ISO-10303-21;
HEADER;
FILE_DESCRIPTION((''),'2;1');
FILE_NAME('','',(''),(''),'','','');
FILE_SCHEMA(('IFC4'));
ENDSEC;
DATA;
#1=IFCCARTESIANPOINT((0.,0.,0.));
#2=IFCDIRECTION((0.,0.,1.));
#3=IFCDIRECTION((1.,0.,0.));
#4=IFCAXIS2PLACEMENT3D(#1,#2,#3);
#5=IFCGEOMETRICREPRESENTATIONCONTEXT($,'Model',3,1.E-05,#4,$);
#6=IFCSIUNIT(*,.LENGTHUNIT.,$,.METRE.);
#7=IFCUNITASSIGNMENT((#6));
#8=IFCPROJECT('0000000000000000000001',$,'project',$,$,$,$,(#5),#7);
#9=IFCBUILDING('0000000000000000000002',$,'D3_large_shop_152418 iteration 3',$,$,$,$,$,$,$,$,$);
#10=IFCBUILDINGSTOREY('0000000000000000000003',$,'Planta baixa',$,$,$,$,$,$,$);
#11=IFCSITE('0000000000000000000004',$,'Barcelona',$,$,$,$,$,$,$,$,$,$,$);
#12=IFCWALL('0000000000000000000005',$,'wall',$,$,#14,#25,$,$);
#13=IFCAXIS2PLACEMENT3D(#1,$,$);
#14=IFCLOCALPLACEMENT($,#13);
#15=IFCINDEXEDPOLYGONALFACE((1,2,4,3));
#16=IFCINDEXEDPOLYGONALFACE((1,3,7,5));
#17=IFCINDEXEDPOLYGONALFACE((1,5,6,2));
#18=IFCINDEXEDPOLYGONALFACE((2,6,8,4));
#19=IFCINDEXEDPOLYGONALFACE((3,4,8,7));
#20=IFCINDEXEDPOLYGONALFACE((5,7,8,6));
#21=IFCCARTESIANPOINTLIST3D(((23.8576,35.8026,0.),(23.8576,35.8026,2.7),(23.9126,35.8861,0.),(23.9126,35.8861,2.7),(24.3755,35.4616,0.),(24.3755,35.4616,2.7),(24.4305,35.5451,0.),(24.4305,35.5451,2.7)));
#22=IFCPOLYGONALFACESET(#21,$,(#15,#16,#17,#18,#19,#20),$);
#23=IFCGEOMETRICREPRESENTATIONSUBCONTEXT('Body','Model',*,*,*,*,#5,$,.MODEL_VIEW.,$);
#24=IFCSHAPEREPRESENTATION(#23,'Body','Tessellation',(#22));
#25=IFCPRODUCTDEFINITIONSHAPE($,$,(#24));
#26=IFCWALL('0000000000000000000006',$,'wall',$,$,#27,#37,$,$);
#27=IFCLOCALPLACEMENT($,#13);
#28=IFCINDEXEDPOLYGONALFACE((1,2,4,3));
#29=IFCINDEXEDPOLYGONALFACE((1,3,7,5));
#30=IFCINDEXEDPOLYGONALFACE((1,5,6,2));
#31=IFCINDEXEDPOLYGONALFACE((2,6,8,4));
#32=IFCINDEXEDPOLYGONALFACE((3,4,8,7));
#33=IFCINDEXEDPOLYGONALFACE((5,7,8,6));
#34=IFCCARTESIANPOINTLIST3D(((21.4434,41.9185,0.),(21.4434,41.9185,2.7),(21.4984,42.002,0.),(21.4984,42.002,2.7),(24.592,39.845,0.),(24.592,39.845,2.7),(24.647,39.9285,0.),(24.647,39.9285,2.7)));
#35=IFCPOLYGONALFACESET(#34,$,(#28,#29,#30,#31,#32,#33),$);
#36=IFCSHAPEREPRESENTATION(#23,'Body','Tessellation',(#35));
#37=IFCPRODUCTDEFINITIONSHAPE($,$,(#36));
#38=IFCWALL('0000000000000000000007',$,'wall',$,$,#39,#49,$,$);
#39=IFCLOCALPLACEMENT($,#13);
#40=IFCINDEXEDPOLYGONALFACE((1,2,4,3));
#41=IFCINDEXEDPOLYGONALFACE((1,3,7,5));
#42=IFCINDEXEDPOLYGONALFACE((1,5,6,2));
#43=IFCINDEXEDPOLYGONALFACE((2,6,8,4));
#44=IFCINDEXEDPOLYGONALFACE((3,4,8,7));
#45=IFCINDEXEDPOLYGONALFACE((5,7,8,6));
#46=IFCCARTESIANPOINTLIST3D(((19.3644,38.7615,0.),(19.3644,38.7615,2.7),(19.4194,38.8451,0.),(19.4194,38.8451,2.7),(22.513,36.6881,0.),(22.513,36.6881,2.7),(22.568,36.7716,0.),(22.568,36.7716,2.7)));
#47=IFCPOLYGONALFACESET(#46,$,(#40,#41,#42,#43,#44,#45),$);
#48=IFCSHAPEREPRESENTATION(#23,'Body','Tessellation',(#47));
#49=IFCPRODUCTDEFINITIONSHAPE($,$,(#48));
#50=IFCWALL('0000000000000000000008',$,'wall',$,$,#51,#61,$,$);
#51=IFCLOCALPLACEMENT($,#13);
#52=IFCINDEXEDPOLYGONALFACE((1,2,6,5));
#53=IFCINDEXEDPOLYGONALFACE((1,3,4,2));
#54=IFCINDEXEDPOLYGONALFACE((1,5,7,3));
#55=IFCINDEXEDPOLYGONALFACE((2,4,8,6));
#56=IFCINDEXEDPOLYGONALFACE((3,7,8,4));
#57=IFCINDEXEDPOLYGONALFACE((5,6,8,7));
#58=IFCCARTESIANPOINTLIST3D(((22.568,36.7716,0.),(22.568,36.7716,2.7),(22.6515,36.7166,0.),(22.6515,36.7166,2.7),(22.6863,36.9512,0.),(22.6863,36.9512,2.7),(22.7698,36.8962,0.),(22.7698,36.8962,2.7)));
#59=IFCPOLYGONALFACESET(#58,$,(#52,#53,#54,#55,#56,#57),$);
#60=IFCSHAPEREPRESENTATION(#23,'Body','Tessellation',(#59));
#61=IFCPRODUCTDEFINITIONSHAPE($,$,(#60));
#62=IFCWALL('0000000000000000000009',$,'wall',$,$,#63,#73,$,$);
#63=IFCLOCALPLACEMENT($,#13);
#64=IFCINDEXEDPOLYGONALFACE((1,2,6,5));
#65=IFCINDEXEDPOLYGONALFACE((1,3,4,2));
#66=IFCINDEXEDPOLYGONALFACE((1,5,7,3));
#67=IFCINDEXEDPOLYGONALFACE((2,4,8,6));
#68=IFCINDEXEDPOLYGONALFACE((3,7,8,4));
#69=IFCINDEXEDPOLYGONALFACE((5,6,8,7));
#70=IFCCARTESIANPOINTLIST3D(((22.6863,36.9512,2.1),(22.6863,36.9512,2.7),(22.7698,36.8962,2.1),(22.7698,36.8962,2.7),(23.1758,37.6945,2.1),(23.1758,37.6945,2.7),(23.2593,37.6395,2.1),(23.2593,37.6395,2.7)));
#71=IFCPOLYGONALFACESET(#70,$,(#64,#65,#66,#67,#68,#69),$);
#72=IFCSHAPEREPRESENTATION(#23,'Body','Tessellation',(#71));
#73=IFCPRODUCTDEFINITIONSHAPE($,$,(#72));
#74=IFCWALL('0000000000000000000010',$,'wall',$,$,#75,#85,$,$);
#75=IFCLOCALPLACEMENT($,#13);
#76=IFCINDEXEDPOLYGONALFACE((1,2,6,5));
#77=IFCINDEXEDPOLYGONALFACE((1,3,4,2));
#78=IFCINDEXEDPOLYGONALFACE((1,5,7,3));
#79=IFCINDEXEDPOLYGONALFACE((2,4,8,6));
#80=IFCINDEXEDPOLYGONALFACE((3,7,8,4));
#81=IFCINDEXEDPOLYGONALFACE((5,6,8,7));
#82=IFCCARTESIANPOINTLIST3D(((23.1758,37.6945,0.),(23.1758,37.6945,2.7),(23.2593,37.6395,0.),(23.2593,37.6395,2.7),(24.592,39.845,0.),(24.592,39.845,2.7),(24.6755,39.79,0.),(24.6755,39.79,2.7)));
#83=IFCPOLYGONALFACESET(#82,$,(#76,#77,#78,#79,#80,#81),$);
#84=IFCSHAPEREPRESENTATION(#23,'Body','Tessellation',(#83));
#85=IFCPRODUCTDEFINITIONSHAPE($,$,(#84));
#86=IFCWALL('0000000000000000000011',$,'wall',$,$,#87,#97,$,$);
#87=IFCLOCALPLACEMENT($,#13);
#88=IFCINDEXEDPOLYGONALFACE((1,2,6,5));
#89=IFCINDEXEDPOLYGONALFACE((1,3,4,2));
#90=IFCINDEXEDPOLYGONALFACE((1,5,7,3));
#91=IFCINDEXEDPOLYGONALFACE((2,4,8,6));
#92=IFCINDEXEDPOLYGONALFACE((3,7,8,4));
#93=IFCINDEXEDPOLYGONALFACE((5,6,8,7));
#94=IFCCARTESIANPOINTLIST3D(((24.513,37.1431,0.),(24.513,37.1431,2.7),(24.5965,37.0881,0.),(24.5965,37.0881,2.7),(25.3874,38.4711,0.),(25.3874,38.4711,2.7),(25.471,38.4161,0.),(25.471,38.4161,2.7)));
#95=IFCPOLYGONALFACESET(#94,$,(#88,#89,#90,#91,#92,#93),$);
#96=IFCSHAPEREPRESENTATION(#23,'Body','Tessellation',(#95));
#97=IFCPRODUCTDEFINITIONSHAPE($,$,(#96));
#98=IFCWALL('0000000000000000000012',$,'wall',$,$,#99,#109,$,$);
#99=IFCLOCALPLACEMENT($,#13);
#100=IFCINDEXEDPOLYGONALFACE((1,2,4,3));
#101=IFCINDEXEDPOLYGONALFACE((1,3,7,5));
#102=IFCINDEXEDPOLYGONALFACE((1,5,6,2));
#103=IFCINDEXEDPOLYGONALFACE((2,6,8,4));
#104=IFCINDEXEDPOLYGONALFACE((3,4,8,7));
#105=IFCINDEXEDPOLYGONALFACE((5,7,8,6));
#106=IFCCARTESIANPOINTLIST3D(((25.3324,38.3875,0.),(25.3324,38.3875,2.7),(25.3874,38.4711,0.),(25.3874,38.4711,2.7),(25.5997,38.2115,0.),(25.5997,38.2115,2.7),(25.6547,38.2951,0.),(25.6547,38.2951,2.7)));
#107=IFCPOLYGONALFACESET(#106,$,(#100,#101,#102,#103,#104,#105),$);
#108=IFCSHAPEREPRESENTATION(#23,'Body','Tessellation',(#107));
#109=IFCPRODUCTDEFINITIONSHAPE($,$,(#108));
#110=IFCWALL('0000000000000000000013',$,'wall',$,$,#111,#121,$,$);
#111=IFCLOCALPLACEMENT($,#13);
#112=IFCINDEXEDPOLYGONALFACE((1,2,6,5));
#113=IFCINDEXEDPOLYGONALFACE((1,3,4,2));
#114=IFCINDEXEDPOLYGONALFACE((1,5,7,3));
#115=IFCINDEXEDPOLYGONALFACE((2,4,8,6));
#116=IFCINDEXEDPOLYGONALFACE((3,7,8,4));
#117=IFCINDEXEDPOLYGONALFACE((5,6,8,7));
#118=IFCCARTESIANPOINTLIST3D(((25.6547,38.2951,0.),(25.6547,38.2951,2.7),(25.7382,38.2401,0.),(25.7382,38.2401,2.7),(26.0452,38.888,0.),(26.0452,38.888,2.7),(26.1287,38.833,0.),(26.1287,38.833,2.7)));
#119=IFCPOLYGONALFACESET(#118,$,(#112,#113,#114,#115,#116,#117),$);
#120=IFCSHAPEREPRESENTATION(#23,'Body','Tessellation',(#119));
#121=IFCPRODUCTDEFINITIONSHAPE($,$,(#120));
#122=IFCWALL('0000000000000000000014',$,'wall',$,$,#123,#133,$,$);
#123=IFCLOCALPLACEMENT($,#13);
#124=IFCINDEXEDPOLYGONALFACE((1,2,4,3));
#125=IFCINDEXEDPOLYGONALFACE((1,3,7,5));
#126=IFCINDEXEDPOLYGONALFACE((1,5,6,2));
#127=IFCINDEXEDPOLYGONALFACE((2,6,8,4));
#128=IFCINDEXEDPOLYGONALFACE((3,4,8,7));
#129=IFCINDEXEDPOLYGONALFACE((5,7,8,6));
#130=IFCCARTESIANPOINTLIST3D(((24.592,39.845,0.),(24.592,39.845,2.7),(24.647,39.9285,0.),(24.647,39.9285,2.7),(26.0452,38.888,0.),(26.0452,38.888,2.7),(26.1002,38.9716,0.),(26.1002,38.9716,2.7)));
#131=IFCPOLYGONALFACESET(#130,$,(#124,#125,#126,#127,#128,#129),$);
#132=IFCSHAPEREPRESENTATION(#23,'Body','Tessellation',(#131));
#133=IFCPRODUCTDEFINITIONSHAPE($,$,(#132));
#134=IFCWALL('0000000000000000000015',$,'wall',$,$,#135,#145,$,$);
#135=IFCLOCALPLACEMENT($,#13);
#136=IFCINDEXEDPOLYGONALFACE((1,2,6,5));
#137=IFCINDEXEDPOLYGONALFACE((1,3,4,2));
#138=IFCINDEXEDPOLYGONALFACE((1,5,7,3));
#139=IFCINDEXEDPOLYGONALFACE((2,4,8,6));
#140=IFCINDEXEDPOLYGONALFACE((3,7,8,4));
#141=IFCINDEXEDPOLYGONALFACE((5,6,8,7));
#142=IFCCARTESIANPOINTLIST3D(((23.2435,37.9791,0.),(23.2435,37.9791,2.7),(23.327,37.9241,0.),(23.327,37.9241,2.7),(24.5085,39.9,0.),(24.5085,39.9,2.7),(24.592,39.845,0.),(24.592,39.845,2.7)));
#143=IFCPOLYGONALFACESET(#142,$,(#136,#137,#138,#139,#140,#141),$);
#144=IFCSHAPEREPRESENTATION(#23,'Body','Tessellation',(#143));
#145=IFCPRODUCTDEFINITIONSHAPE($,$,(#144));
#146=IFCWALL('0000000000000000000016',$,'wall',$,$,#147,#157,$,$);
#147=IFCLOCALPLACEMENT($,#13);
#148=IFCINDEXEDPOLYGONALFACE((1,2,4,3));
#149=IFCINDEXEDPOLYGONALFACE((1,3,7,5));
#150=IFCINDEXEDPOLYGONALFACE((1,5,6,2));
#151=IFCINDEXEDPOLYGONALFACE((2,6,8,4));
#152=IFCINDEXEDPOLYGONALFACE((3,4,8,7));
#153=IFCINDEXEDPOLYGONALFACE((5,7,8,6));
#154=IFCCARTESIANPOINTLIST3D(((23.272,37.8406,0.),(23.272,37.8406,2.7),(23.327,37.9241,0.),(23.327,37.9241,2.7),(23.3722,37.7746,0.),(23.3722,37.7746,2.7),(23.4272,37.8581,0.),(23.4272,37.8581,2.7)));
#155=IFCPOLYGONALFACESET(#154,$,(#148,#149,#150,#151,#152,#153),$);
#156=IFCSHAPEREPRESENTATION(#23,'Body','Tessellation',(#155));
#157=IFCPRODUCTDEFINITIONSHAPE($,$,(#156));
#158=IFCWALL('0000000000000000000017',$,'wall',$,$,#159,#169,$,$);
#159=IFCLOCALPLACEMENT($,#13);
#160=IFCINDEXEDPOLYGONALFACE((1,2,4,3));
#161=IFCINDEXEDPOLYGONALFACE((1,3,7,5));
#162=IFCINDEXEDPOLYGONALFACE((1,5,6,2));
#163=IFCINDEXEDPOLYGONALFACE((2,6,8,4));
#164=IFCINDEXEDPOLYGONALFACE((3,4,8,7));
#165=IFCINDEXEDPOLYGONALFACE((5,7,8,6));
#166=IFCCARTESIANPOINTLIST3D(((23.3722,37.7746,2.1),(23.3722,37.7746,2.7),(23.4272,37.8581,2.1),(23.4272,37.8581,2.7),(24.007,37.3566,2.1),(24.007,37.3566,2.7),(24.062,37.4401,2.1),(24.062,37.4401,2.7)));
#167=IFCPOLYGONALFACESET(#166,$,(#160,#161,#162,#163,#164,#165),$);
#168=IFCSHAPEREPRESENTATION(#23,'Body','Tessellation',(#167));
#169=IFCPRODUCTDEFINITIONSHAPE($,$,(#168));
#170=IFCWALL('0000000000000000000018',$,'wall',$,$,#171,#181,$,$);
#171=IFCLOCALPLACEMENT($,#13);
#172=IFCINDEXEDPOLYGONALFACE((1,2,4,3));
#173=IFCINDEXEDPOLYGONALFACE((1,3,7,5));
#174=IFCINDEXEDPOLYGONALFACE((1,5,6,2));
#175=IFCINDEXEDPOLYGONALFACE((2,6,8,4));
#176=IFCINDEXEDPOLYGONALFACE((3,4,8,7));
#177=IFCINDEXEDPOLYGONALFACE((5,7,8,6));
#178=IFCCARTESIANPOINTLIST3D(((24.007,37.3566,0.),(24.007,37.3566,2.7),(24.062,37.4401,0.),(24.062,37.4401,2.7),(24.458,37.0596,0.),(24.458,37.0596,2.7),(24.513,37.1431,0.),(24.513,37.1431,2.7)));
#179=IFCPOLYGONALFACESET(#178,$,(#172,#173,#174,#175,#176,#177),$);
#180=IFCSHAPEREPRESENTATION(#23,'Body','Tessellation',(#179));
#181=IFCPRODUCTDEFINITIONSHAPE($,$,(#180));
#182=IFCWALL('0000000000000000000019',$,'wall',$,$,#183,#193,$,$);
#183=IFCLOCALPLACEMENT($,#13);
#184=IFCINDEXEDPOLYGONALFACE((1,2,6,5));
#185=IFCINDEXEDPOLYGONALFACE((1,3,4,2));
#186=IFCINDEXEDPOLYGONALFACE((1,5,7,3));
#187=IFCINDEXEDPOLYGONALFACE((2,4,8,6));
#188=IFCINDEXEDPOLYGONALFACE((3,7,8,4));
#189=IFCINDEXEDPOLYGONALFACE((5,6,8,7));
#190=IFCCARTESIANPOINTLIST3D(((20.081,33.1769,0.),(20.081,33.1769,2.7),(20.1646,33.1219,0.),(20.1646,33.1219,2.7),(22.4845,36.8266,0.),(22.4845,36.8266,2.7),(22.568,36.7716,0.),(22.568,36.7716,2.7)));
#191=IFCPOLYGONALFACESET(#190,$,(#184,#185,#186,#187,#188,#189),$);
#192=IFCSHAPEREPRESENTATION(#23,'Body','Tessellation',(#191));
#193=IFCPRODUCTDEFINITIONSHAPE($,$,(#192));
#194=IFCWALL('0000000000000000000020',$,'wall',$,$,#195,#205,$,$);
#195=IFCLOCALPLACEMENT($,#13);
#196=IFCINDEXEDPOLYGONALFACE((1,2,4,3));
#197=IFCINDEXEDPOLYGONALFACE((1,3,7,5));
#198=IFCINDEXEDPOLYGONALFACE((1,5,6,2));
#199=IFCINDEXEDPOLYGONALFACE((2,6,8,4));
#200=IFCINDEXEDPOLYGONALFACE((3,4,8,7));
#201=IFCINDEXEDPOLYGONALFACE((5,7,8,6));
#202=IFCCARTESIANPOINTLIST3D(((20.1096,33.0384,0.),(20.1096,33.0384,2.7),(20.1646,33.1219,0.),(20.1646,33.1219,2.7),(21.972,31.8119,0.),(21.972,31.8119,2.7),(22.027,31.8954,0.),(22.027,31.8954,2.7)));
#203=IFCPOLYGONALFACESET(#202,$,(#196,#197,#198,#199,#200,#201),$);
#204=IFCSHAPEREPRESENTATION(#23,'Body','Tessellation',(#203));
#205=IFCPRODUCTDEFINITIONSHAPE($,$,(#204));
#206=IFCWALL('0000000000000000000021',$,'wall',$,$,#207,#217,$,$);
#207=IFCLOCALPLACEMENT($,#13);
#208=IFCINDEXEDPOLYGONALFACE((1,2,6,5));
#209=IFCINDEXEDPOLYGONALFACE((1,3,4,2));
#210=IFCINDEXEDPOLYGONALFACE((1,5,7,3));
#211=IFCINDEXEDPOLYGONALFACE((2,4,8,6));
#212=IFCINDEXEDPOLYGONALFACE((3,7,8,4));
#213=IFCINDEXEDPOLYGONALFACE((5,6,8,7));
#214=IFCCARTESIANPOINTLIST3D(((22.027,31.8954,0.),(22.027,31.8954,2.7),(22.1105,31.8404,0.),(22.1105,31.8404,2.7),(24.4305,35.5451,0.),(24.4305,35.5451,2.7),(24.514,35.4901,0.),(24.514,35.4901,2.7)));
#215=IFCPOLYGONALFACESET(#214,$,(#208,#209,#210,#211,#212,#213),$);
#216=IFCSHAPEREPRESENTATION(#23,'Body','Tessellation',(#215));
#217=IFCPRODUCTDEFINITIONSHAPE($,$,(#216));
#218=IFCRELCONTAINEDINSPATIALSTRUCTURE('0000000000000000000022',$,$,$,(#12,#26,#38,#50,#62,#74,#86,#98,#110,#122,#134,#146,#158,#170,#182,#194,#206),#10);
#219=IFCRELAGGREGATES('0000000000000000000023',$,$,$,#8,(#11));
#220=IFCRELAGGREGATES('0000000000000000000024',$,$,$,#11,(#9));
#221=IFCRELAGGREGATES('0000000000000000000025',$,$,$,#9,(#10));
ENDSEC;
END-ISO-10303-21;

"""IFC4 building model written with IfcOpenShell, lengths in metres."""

from ifc_helpers import new_model, si_unit, frame, origin, origin_with_axes, place, context, subcontext, project, spatial, polyline, outline, extrude, element, save


model = new_model("IFC4")

# Units and contexts
model_context = context("Model", 3, precision=1e-05, world=origin_with_axes())
body_context = subcontext(model_context, "Body", "Model", "MODEL_VIEW")
ifc_project = project(units=[si_unit("LENGTHUNIT", "METRE")], contexts=[model_context])

# Site, building, storey
site = spatial("IfcSite", under=ifc_project, Name="Barcelona")
building = spatial("IfcBuilding", under=site, Name="D3_large_shop_152418 iteration 3")
storey = spatial("IfcBuildingStorey", under=building, Name="Planta baixa")

# Walls
wall_1_placement = place(None, origin_with_axes())
element("IfcWall", 1, at=wall_1_placement, inside=storey, Name="wall", context=body_context, shape_type="SweptSolid", body=[
    extrude(outline(polyline([(23.9126, 35.8861), (24.4305, 35.5451), (24.3755, 35.4616), (23.8576, 35.8026), (23.9126, 35.8861)])), origin(), (0.0, 0.0, 1.0), 2.7),
])
wall_2_placement = place(None, origin_with_axes())
element("IfcWall", 2, at=wall_2_placement, inside=storey, Name="wall", context=body_context, shape_type="SweptSolid", body=[
    extrude(outline(polyline([(24.592, 39.845), (21.4434, 41.9185), (21.4984, 42.002), (24.647, 39.9285), (24.592, 39.845)])), origin(), (0.0, 0.0, 1.0), 2.7),
])
wall_3_placement = place(None, origin_with_axes())
element("IfcWall", 3, at=wall_3_placement, inside=storey, Name="wall", context=body_context, shape_type="SweptSolid", body=[
    extrude(outline(polyline([(19.4194, 38.8451), (22.568, 36.7716), (22.513, 36.6881), (19.3644, 38.7615), (19.4194, 38.8451)])), origin(), (0.0, 0.0, 1.0), 2.7),
])
wall_4_placement = place(None, origin_with_axes())
element("IfcWall", 4, at=wall_4_placement, inside=storey, Name="wall", context=body_context, shape_type="SweptSolid", body=[
    extrude(outline(polyline([(22.568, 36.7716), (22.6863, 36.9512), (22.7698, 36.8962), (22.6515, 36.7166), (22.568, 36.7716)])), origin(), (0.0, 0.0, 1.0), 2.7),
])
wall_5_placement = place(None, origin_with_axes())
element("IfcWall", 5, at=wall_5_placement, inside=storey, Name="wall", context=body_context, shape_type="SweptSolid", body=[
    extrude(outline(polyline([(22.6863, 36.9512), (23.1758, 37.6945), (23.2593, 37.6395), (22.7698, 36.8962), (22.6863, 36.9512)])), frame((0.0, 0.0, 2.1)), (0.0, 0.0, 1.0), 0.6),
])
wall_6_placement = place(None, origin_with_axes())
element("IfcWall", 6, at=wall_6_placement, inside=storey, Name="wall", context=body_context, shape_type="SweptSolid", body=[
    extrude(outline(polyline([(23.1758, 37.6945), (24.592, 39.845), (24.6755, 39.79), (23.2593, 37.6395), (23.1758, 37.6945)])), origin(), (0.0, 0.0, 1.0), 2.7),
])
wall_7_placement = place(None, origin_with_axes())
element("IfcWall", 7, at=wall_7_placement, inside=storey, Name="wall", context=body_context, shape_type="SweptSolid", body=[
    extrude(outline(polyline([(24.513, 37.1431), (25.3874, 38.4711), (25.471, 38.4161), (24.5965, 37.0881), (24.513, 37.1431)])), origin(), (0.0, 0.0, 1.0), 2.7),
])
wall_8_placement = place(None, origin_with_axes())
element("IfcWall", 8, at=wall_8_placement, inside=storey, Name="wall", context=body_context, shape_type="SweptSolid", body=[
    extrude(outline(polyline([(25.3874, 38.4711), (25.6547, 38.2951), (25.5997, 38.2115), (25.3324, 38.3875), (25.3874, 38.4711)])), origin(), (0.0, 0.0, 1.0), 2.7),
])
wall_9_placement = place(None, origin_with_axes())
element("IfcWall", 9, at=wall_9_placement, inside=storey, Name="wall", context=body_context, shape_type="SweptSolid", body=[
    extrude(outline(polyline([(25.6547, 38.2951), (26.0452, 38.888), (26.1287, 38.833), (25.7382, 38.2401), (25.6547, 38.2951)])), origin(), (0.0, 0.0, 1.0), 2.7),
])
wall_10_placement = place(None, origin_with_axes())
element("IfcWall", 10, at=wall_10_placement, inside=storey, Name="wall", context=body_context, shape_type="SweptSolid", body=[
    extrude(outline(polyline([(26.0452, 38.888), (24.592, 39.845), (24.647, 39.9285), (26.1002, 38.9716), (26.0452, 38.888)])), origin(), (0.0, 0.0, 1.0), 2.7),
])
wall_11_placement = place(None, origin_with_axes())
element("IfcWall", 11, at=wall_11_placement, inside=storey, Name="wall", context=body_context, shape_type="SweptSolid", body=[
    extrude(outline(polyline([(24.592, 39.845), (23.327, 37.9241), (23.2435, 37.9791), (24.5085, 39.9), (24.592, 39.845)])), origin(), (0.0, 0.0, 1.0), 2.7),
])
wall_12_placement = place(None, origin_with_axes())
element("IfcWall", 12, at=wall_12_placement, inside=storey, Name="wall", context=body_context, shape_type="SweptSolid", body=[
    extrude(outline(polyline([(23.327, 37.9241), (23.4272, 37.8581), (23.3722, 37.7746), (23.272, 37.8406), (23.327, 37.9241)])), origin(), (0.0, 0.0, 1.0), 2.7),
])
wall_13_placement = place(None, origin_with_axes())
element("IfcWall", 13, at=wall_13_placement, inside=storey, Name="wall", context=body_context, shape_type="SweptSolid", body=[
    extrude(outline(polyline([(23.4272, 37.8581), (24.062, 37.4401), (24.007, 37.3566), (23.3722, 37.7746), (23.4272, 37.8581)])), frame((0.0, 0.0, 2.1)), (0.0, 0.0, 1.0), 0.6),
])
wall_14_placement = place(None, origin_with_axes())
element("IfcWall", 14, at=wall_14_placement, inside=storey, Name="wall", context=body_context, shape_type="SweptSolid", body=[
    extrude(outline(polyline([(24.062, 37.4401), (24.513, 37.1431), (24.458, 37.0596), (24.007, 37.3566), (24.062, 37.4401)])), origin(), (0.0, 0.0, 1.0), 2.7),
])
wall_15_placement = place(None, origin_with_axes())
element("IfcWall", 15, at=wall_15_placement, inside=storey, Name="wall", context=body_context, shape_type="SweptSolid", body=[
    extrude(outline(polyline([(22.568, 36.7716), (20.1646, 33.1219), (20.081, 33.1769), (22.4845, 36.8266), (22.568, 36.7716)])), origin(), (0.0, 0.0, 1.0), 2.7),
])
wall_16_placement = place(None, origin_with_axes())
element("IfcWall", 16, at=wall_16_placement, inside=storey, Name="wall", context=body_context, shape_type="SweptSolid", body=[
    extrude(outline(polyline([(20.1646, 33.1219), (22.027, 31.8954), (21.972, 31.8119), (20.1096, 33.0384), (20.1646, 33.1219)])), origin(), (0.0, 0.0, 1.0), 2.7),
])
wall_17_placement = place(None, origin_with_axes())
element("IfcWall", 17, at=wall_17_placement, inside=storey, Name="wall", context=body_context, shape_type="SweptSolid", body=[
    extrude(outline(polyline([(22.027, 31.8954), (24.4305, 35.5451), (24.514, 35.4901), (22.1105, 31.8404), (22.027, 31.8954)])), origin(), (0.0, 0.0, 1.0), 2.7),
])

save(model, "model.ifc")
